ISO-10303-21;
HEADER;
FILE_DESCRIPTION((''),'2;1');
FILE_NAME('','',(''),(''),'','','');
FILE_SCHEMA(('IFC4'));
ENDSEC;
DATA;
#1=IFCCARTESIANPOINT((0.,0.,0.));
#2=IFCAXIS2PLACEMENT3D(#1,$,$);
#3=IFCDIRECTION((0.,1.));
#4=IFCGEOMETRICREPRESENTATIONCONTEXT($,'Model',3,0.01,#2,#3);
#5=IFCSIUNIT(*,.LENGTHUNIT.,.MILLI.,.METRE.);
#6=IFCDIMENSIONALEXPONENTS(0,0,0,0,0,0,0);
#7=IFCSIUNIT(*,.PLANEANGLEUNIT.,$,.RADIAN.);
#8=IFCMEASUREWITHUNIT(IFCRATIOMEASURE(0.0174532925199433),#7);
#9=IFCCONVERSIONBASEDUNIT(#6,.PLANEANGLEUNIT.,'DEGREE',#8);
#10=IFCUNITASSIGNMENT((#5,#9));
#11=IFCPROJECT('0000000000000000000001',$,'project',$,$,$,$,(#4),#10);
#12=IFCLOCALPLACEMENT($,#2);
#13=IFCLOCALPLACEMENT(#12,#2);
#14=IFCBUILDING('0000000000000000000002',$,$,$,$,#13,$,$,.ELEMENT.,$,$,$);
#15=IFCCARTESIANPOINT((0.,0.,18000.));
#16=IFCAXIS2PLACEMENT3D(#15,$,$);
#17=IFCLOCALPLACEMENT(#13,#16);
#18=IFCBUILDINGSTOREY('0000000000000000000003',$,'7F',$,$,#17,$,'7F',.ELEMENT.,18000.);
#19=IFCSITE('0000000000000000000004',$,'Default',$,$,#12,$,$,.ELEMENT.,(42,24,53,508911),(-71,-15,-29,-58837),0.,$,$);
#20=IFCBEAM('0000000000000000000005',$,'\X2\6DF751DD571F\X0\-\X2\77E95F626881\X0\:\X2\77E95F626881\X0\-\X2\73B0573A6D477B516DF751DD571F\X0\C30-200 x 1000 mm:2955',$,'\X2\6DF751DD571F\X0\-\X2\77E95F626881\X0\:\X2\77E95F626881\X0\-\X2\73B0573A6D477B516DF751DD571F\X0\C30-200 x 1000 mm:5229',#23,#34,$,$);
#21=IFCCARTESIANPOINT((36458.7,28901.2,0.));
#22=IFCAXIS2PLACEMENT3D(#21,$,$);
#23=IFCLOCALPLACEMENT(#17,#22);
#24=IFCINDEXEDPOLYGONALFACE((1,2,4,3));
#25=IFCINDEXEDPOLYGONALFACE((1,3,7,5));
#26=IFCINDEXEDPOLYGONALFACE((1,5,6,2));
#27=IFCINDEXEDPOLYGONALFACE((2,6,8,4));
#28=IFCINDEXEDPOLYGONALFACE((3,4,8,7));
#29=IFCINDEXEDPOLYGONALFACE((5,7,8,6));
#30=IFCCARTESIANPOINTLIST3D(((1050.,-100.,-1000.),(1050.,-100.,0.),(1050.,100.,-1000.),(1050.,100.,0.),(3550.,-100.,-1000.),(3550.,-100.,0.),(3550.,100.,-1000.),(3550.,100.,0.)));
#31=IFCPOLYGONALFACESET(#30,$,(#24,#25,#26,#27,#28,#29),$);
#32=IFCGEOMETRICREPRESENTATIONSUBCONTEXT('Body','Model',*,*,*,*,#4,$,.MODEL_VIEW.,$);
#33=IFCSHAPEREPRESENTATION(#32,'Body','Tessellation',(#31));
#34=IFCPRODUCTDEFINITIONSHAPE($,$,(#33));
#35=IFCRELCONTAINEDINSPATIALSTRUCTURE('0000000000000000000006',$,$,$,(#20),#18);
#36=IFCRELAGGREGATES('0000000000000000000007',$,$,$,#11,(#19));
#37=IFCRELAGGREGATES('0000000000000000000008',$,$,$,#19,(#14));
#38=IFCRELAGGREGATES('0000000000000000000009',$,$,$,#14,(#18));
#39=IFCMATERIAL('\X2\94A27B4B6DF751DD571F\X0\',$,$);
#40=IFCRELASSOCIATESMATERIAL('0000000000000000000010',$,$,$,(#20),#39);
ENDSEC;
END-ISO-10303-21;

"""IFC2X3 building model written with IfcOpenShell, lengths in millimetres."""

from ifc_helpers import new_model, entity, si_unit, converted_unit, direction, frame, frame_2d, origin, place, context, subcontext, project, spatial, rectangle, extrude, material, element, save


model = new_model("IFC2X3")

# Units and contexts
model_context = context("Model", 3, precision=0.01, world=origin(), true_north=direction((0.0, 1.0)))
body_context = subcontext(model_context, "Body", "Model", "MODEL_VIEW")
ifc_project = project(units=[si_unit("LENGTHUNIT", "METRE", prefix="MILLI"), converted_unit("PLANEANGLEUNIT", "DEGREE", entity("IfcRatioMeasure", 0.0174532925199433), si_unit("PLANEANGLEUNIT", "RADIAN"), dimensions=[0, 0, 0, 0, 0, 0, 0])], contexts=[model_context])

# Site, building, storey
site_placement = place(None, origin())
site = spatial("IfcSite", under=ifc_project, at=site_placement, Name="Default", CompositionType="ELEMENT", RefLatitude=(42, 24, 53, 508911), RefLongitude=(-71, -15, -29, -58837), RefElevation=0.0)
building_placement = place(site_placement, origin())
building = spatial("IfcBuilding", under=site, at=building_placement, CompositionType="ELEMENT")
storey_placement = place(building_placement, frame((0.0, 0.0, 18000.0)))
storey = spatial("IfcBuildingStorey", under=building, at=storey_placement, Name="7F", LongName="7F", CompositionType="ELEMENT", Elevation=18000.0)

# Beam
ifc_material = material(Name="钢筋混凝土")
beam_1_placement = place(storey_placement, frame((36458.7, 28901.2, 0.0)))
element("IfcBeam", 1, at=beam_1_placement, inside=storey, material=ifc_material, Name="混凝土-矩形梁:矩形梁-现场浇筑混凝土C30-200 x 1000 mm:2955", ObjectType="混凝土-矩形梁:矩形梁-现场浇筑混凝土C30-200 x 1000 mm:5229", context=body_context, shape_type="SweptSolid", body=[
    extrude(rectangle(XDim=1000.0, YDim=200.0, at=frame_2d((0.0, 0.0), x_axis=(1.0, 0.0))), frame((1050.0, 0.0, -500.0), z_axis=(1.0, 0.0, 0.0), x_axis=(0.0, 0.0, -1.0)), (0.0, 0.0, 1.0), 2500.0),
])

save(model, "model.ifc")
